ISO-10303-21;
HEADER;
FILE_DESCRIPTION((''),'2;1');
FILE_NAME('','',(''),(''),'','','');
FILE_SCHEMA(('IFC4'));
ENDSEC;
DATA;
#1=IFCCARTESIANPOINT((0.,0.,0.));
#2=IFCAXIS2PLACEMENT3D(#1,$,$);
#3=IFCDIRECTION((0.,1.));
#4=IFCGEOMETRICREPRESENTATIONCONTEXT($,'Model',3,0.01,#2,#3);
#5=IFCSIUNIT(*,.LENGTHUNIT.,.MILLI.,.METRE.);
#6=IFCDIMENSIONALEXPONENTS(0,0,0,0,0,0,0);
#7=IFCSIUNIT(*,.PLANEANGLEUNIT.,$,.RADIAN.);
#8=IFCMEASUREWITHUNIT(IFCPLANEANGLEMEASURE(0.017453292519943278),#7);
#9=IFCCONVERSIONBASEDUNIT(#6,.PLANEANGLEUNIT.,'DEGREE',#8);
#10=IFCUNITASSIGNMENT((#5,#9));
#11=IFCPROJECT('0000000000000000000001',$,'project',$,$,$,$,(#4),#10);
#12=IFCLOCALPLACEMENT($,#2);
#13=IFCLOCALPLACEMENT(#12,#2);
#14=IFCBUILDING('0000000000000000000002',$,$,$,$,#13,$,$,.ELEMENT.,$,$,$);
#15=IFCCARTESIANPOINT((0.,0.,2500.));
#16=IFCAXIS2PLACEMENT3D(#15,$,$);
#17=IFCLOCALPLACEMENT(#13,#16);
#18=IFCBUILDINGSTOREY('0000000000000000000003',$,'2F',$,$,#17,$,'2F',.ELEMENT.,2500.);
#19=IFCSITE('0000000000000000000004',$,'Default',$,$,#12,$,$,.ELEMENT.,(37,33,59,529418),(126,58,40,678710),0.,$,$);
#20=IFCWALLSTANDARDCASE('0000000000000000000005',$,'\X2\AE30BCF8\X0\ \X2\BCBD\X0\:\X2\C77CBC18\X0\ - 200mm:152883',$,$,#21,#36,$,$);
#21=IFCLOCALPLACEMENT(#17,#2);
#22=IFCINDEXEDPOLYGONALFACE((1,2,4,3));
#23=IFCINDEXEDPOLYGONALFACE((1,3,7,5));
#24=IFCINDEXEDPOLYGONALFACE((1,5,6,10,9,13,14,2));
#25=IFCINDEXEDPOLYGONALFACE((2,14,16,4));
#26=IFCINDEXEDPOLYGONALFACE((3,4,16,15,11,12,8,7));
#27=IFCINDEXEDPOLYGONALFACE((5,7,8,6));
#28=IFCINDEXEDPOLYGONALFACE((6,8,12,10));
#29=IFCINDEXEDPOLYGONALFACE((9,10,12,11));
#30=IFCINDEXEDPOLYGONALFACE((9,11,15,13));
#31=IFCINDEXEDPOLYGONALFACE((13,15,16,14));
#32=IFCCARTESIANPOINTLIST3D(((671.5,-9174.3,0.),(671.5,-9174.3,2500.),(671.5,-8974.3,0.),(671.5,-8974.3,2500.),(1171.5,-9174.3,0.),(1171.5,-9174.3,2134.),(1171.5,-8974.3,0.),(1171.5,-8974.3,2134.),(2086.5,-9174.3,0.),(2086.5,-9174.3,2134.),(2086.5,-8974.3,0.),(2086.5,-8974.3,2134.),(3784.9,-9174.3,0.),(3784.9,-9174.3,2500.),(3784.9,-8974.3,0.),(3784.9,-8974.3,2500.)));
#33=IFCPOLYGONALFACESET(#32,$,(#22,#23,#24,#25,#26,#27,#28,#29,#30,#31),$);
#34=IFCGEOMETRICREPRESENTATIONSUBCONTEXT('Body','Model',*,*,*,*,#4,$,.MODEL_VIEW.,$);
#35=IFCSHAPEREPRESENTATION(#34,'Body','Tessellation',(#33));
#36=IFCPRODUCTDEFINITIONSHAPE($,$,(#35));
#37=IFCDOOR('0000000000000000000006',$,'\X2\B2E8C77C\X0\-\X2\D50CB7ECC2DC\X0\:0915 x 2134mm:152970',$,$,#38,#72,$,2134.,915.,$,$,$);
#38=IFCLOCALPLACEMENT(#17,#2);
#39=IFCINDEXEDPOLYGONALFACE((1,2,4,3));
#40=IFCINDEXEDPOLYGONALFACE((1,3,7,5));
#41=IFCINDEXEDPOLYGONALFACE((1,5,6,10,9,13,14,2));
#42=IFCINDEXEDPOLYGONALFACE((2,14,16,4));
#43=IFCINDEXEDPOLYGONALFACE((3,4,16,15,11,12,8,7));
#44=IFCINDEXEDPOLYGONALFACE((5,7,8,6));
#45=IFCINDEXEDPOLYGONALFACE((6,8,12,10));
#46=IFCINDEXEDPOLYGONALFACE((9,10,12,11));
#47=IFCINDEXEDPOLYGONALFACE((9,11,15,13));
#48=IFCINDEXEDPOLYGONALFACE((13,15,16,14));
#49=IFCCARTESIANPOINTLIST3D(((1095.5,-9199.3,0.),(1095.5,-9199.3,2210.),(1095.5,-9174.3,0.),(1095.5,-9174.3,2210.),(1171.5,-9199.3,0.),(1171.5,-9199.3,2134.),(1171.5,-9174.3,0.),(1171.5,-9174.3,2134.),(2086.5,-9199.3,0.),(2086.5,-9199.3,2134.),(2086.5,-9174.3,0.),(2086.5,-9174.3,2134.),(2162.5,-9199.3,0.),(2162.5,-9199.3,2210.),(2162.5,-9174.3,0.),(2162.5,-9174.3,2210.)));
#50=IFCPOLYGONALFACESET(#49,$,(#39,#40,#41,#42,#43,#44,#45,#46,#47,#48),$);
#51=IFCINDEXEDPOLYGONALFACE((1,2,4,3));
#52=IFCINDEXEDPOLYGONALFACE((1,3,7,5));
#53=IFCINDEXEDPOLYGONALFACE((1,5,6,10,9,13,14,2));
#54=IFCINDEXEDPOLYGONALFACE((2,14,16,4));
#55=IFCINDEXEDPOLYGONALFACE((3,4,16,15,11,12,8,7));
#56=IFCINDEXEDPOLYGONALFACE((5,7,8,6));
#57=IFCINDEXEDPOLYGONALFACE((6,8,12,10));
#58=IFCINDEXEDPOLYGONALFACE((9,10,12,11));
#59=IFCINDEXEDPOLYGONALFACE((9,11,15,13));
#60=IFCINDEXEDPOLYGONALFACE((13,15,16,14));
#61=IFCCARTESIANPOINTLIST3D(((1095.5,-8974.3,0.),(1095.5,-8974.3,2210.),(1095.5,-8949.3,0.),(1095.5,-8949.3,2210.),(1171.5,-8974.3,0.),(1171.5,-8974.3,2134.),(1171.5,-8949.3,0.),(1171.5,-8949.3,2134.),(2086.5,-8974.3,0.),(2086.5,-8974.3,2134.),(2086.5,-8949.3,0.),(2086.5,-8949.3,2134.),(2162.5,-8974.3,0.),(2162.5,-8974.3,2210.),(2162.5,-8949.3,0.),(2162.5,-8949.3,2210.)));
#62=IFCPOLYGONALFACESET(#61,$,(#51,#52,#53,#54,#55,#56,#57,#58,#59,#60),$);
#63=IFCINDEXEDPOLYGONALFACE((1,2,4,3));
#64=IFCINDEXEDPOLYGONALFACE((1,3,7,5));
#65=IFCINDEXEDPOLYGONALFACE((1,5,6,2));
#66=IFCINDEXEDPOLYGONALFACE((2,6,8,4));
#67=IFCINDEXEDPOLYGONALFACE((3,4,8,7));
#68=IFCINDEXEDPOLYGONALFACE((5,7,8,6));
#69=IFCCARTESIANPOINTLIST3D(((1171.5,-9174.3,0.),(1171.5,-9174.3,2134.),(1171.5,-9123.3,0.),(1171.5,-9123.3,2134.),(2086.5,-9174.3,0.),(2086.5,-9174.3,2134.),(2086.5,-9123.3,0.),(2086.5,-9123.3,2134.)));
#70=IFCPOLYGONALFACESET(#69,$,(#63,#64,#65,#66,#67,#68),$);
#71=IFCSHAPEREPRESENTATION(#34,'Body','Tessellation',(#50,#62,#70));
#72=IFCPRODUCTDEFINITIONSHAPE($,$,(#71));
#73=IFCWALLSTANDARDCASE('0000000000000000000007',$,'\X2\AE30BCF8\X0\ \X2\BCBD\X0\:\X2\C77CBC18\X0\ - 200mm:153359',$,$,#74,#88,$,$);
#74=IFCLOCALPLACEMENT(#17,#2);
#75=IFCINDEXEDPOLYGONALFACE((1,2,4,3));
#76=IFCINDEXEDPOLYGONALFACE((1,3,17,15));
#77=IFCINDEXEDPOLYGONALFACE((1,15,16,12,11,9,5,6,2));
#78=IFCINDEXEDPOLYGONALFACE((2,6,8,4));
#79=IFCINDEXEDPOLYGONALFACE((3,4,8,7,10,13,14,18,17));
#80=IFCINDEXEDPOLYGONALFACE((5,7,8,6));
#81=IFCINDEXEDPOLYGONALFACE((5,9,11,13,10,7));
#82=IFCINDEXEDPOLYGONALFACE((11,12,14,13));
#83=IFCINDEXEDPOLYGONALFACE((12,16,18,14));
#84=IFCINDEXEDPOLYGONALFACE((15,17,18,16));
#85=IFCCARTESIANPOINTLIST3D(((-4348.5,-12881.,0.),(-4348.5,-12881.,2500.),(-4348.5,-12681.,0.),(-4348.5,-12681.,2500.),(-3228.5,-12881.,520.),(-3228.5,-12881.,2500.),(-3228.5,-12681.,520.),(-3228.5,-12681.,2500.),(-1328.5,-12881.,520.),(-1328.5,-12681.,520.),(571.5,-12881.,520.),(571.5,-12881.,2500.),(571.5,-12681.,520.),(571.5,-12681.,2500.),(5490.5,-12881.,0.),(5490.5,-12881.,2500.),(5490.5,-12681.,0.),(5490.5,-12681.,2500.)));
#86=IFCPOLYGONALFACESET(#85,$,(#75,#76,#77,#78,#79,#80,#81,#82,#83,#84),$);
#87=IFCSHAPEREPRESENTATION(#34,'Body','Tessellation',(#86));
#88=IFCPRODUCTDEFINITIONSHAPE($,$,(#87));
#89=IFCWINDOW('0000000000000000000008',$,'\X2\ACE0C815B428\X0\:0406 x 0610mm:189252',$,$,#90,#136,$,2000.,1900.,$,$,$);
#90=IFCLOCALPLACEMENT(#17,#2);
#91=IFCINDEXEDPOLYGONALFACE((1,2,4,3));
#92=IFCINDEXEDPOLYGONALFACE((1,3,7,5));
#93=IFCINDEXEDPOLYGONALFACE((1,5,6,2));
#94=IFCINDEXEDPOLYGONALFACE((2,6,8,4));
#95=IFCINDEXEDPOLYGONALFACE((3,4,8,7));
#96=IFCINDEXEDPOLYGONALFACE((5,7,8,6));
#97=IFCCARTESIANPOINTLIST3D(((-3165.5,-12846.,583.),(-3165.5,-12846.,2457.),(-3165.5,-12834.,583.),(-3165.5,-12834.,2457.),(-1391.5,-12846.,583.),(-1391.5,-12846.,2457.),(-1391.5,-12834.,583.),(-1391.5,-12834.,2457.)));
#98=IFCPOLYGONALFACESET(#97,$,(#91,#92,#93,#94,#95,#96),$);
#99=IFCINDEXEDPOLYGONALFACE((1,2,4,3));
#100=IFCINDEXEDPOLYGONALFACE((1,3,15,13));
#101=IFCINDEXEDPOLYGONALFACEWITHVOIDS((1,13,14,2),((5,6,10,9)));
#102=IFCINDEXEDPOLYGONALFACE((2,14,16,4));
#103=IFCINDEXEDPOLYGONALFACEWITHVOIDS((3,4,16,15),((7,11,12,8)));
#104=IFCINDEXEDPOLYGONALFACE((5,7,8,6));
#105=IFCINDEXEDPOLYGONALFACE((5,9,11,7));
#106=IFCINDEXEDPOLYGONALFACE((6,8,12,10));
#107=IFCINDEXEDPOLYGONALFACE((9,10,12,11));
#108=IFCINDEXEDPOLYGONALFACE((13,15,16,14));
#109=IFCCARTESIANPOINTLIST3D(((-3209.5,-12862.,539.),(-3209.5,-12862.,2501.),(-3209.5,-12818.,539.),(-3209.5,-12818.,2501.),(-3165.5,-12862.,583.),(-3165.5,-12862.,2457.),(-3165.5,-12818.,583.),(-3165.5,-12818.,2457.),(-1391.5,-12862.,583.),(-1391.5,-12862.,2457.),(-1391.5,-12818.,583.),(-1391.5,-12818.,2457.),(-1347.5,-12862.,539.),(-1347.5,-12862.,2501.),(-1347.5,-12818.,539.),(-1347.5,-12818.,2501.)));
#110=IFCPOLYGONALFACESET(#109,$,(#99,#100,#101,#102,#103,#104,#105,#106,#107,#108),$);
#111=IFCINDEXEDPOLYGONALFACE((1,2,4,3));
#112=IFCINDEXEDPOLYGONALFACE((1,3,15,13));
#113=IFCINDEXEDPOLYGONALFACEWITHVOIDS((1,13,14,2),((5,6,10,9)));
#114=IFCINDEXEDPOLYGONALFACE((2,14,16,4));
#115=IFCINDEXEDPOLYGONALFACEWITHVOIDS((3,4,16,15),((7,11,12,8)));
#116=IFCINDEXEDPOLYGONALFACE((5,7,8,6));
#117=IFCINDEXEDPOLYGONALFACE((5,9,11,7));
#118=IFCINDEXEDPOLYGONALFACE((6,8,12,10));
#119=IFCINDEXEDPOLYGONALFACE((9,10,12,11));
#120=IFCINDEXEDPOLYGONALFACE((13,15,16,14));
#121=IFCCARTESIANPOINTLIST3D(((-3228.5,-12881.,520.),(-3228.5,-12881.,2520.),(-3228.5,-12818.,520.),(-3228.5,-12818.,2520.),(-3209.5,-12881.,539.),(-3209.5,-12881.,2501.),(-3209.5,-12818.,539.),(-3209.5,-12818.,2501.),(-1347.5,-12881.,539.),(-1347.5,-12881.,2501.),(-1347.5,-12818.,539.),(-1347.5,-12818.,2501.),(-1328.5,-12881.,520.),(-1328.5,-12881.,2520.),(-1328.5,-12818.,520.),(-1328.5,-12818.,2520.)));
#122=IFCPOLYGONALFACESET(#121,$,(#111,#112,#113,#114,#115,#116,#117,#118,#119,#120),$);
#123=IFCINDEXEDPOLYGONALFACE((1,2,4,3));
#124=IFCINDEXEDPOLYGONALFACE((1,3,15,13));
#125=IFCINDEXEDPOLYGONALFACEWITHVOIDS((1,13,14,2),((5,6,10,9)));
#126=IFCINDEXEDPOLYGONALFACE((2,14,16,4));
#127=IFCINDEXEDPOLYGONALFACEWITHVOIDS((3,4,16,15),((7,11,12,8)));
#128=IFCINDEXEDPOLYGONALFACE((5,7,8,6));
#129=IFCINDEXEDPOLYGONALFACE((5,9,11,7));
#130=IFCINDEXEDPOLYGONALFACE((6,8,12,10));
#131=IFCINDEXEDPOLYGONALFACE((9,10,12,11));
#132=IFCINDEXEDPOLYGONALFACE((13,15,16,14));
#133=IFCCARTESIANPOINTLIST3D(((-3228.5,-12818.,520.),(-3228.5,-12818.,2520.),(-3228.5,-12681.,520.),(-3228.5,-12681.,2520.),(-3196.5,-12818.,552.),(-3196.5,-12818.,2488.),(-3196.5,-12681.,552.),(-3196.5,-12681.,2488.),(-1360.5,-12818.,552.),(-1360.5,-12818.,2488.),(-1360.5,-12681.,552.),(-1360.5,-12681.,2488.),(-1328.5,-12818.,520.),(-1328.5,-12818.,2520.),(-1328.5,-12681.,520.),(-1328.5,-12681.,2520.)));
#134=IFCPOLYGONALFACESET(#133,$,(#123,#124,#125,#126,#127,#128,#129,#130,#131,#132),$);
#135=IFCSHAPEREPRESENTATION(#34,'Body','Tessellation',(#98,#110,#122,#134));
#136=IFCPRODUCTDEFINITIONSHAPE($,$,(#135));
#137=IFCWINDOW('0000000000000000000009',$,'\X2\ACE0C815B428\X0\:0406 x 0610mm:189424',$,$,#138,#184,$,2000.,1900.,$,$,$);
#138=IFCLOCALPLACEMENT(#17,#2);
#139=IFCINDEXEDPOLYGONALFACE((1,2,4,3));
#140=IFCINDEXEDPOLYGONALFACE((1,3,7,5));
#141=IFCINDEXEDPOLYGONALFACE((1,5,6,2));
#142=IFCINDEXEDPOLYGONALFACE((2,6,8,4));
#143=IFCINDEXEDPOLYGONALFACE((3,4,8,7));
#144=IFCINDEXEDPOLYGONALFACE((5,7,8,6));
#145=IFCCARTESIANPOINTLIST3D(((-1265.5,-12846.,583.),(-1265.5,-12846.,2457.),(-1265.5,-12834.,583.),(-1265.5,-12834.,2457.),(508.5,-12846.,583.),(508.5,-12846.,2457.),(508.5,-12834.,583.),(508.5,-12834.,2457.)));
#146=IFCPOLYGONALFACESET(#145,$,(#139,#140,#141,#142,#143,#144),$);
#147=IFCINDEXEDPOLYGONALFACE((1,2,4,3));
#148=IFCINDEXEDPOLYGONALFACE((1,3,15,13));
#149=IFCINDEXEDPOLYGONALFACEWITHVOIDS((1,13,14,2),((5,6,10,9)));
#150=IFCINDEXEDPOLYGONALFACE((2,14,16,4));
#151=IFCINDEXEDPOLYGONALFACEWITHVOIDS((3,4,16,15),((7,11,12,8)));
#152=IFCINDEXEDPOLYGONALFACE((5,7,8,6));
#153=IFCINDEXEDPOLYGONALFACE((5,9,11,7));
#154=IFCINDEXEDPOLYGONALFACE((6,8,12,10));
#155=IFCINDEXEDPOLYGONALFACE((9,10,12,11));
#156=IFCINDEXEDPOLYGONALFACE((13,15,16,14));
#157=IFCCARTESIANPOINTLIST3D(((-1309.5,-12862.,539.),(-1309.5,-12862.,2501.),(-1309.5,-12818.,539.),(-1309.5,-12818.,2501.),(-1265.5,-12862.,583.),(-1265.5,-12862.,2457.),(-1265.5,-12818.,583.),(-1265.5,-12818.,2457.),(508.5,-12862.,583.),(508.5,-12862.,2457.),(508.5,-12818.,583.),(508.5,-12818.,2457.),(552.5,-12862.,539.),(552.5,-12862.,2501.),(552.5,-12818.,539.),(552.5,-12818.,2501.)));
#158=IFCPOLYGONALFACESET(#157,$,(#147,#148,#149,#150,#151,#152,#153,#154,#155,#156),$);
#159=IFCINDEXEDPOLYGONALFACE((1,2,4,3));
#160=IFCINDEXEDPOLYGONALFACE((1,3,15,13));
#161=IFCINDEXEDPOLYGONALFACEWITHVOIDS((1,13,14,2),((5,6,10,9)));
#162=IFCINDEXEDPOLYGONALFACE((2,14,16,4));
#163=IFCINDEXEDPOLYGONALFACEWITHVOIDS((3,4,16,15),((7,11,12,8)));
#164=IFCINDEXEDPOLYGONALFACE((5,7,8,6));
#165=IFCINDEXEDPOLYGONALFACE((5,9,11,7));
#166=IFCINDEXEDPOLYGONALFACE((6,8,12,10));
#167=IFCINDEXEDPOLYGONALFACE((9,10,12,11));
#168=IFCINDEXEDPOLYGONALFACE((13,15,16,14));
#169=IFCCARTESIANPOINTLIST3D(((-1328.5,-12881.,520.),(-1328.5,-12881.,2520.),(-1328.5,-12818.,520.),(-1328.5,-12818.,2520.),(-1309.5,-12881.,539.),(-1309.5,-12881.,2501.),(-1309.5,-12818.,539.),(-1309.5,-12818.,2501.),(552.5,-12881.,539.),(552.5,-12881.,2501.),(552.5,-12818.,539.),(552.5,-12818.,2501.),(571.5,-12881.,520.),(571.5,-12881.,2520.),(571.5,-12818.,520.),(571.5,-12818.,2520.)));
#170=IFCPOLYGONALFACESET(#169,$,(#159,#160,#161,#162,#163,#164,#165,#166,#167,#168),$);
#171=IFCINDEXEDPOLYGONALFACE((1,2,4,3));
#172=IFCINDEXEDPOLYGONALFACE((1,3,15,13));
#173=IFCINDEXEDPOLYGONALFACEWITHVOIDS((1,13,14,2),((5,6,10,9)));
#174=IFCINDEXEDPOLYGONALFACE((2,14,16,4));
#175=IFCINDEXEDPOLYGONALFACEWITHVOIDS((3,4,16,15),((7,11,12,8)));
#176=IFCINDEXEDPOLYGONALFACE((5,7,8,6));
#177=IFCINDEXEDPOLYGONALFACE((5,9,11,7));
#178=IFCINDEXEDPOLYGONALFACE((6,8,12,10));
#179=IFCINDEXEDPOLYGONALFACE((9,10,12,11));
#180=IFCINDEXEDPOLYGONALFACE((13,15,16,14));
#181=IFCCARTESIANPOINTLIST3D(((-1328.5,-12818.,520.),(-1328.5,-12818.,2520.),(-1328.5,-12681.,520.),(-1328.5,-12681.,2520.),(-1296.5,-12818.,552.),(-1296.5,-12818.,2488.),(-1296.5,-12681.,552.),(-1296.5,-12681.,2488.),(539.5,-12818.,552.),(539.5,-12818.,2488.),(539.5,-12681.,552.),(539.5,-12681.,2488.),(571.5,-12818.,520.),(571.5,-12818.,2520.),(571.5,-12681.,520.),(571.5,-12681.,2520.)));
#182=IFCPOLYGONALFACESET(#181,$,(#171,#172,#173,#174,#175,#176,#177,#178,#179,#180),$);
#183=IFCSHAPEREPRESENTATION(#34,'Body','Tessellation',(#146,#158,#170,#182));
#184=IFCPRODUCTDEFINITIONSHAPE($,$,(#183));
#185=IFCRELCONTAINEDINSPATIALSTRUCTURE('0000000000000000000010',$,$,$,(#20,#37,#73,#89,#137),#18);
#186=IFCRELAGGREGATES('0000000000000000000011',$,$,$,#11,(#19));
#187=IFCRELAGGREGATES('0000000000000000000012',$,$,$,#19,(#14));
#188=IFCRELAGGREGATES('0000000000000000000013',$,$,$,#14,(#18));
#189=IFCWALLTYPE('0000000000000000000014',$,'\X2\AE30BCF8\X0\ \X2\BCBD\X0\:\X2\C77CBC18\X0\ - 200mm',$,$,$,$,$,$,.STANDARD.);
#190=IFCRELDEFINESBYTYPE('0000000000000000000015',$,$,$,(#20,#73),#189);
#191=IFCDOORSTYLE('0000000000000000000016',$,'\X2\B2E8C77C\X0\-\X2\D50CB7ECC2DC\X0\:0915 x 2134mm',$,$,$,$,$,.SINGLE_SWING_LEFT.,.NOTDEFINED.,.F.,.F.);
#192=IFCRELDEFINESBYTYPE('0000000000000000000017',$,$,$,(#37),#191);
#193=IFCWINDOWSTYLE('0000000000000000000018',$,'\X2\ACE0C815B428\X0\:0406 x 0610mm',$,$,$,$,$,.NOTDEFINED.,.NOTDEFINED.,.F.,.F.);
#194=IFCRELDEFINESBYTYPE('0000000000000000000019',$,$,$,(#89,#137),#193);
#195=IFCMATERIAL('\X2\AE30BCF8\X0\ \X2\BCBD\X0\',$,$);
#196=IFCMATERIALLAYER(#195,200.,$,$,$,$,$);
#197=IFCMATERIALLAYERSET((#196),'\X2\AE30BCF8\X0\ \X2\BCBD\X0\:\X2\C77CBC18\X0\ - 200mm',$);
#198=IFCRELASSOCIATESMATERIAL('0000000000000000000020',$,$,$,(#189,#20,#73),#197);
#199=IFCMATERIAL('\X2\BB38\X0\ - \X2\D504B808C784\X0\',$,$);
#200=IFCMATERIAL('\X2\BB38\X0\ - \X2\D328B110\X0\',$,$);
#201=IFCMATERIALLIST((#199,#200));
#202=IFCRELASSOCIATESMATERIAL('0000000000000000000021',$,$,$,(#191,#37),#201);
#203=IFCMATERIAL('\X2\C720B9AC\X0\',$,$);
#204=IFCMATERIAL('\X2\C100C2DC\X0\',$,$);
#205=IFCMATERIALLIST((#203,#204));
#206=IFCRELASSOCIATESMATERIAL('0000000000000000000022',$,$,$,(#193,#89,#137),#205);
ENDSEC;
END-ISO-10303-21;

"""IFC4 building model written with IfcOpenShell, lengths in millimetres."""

from ifc_helpers import new_model, entity, si_unit, converted_unit, direction, frame, frame_2d, origin, place, context, subcontext, project, spatial, polyline, rectangle, outline, extrude, source, transform, mapped, material, material_list, layer, layer_set, layer_usage, type_object, type_shapes, element, fill, save


model = new_model("IFC4")

# Units and contexts
model_context = context("Model", 3, precision=0.01, world=origin(), true_north=direction((0.0, 1.0)))
body_context = subcontext(model_context, "Body", "Model", "MODEL_VIEW")
ifc_project = project(units=[si_unit("LENGTHUNIT", "METRE", prefix="MILLI"), converted_unit("PLANEANGLEUNIT", "DEGREE", entity("IfcPlaneAngleMeasure", 0.017453292519943278), si_unit("PLANEANGLEUNIT", "RADIAN"), dimensions=[0, 0, 0, 0, 0, 0, 0])], contexts=[model_context])

# Site, building, storey
site_placement = place(None, origin())
site = spatial("IfcSite", under=ifc_project, at=site_placement, Name="Default", CompositionType="ELEMENT", RefLatitude=(37, 33, 59, 529418), RefLongitude=(126, 58, 40, 678710), RefElevation=0.0)
building_placement = place(site_placement, origin())
building = spatial("IfcBuilding", under=site, at=building_placement, CompositionType="ELEMENT")
storey_placement = place(building_placement, frame((0.0, 0.0, 2500.0)))
storey = spatial("IfcBuildingStorey", under=building, at=storey_placement, Name="2F", LongName="2F", CompositionType="ELEMENT", Elevation=2500.0)

# Wall, opening, door
ifc_material_1 = material(Name="기본 벽")
ifc_layer_1 = layer(ifc_material_1, 200.0)
ifc_layer_set_1 = layer_set([ifc_layer_1], Name="기본 벽:일반 - 200mm")
ifc_layer_usage_1 = layer_usage(ifc_layer_set_1, "AXIS2", "NEGATIVE", 100.0)
wall_type = type_object("IfcWallType", Name="기본 벽:일반 - 200mm", PredefinedType="STANDARD", material=ifc_layer_set_1)
wall_1_placement = place(storey_placement, frame((671.5, -9074.3, 0.0)))
wall_1 = element("IfcWallStandardCase", 1, at=wall_1_placement, inside=storey, type_object=wall_type, material=ifc_layer_usage_1, Name="기본 벽:일반 - 200mm:152883", context=body_context, shape_type="SweptSolid", body=[
    extrude(rectangle(XDim=3113.4, YDim=200.0, at=frame_2d((1556.7, 0.0), x_axis=(-1.0, 0.0))), origin(), (0.0, 0.0, 1.0), 2500.0),
])
opening_1_placement = place(wall_1_placement, frame((1415.0, 100.0, 0.0)))
opening_1 = element("IfcOpeningElement", 2, at=opening_1_placement, cuts=wall_1, ObjectType="Opening", context=body_context, shape_type="SweptSolid", body=[
    extrude(rectangle(XDim=915.0, YDim=2134.0, at=frame_2d((1067.0, 457.5), x_axis=(0.0, -1.0))), frame((0.0, 0.0, 0.0), z_axis=(0.0, -1.0, 0.0), x_axis=(0.0, 0.0, 1.0)), (0.0, 0.0, 1.0), 200.0),
])
ifc_material_2 = material(Name="문 - 프레임")
ifc_material_3 = material(Name="문 - 패널")
ifc_material_list_1 = material_list([ifc_material_2, ifc_material_3])
door_style = type_object("IfcDoorStyle", Name="단일-플러시:0915 x 2134mm", ConstructionType="NOTDEFINED", OperationType="SINGLE_SWING_LEFT", ParameterTakesPrecedence=False, Sizeable=False, material=ifc_material_list_1)
shared_shape_1 = source(origin(), body_context, "Body", "SweptSolid", [
    extrude(outline(polyline([(-533.5, -1124.0), (533.5, -1124.0), (533.5, 1086.0), (457.5, 1086.0), (457.5, -1048.0), (-457.5, -1048.0), (-457.5, 1086.0), (-533.5, 1086.0), (-533.5, -1124.0)])), frame((457.5, 225.0, 1086.0), z_axis=(0.0, -1.0, 0.0), x_axis=(-1.0, 0.0, 0.0)), (0.0, 0.0, 1.0), 25.0),
    extrude(outline(polyline([(-1124.0, -533.5), (1086.0, -533.5), (1086.0, -457.5), (-1048.0, -457.5), (-1048.0, 457.5), (1086.0, 457.5), (1086.0, 533.5), (-1124.0, 533.5), (-1124.0, -533.5)])), frame((457.5, 0.0, 1086.0), z_axis=(0.0, -1.0, 0.0), x_axis=(0.0, 0.0, -1.0)), (0.0, 0.0, 1.0), 25.0),
    extrude(rectangle(XDim=915.0, YDim=51.0, at=frame_2d((0.0, 0.0), x_axis=(1.0, 0.0))), frame((457.5, 174.5, 0.0)), (0.0, 0.0, 1.0), 2134.0),
])
type_shapes(door_style, [shared_shape_1])
door_1_placement = place(opening_1_placement, frame((0.0, 0.0, 0.0), z_axis=(0.0, 0.0, 1.0), x_axis=(-1.0, 0.0, 0.0)))
door_1 = element("IfcDoor", 3, at=door_1_placement, inside=storey, type_object=door_style, material=ifc_material_list_1, Name="단일-플러시:0915 x 2134mm:152970", OverallHeight=2134.0, OverallWidth=915.0, context=body_context, shape_type="MappedRepresentation", body=[
    mapped(shared_shape_1, transform((0.0, 0.0, 0.0), scale=1.0)),
])
fill(opening_1, door_1)

# Wall, openings, windows
ifc_layer_usage_2 = layer_usage(ifc_layer_set_1, "AXIS2", "NEGATIVE", 100.0)
wall_2_placement = place(storey_placement, frame((5490.5, -12781.0, 0.0), z_axis=(0.0, 0.0, 1.0), x_axis=(-1.0, 0.0, 0.0)))
wall_2 = element("IfcWallStandardCase", 4, at=wall_2_placement, inside=storey, type_object=wall_type, material=ifc_layer_usage_2, Name="기본 벽:일반 - 200mm:153359", context=body_context, shape_type="SweptSolid", body=[
    extrude(rectangle(XDim=9839.0, YDim=200.0, at=frame_2d((4919.5, 0.0), x_axis=(-1.0, 0.0))), origin(), (0.0, 0.0, 1.0), 2500.0),
])
opening_2_placement = place(wall_2_placement, frame((6819.0, -100.0, 520.0)))
opening_2 = element("IfcOpeningElement", 5, at=opening_2_placement, cuts=wall_2, ObjectType="Opening", context=body_context, shape_type="SweptSolid", body=[
    extrude(rectangle(XDim=2000.0, YDim=1900.0, at=frame_2d((1000.0, 950.0), x_axis=(1.0, 0.0))), frame((0.0, 0.0, 0.0), z_axis=(0.0, 1.0, 0.0), x_axis=(0.0, 0.0, 1.0)), (0.0, 0.0, 1.0), 200.0),
])
opening_3_placement = place(wall_2_placement, frame((4919.0, -100.0, 520.0)))
opening_3 = element("IfcOpeningElement", 6, at=opening_3_placement, cuts=wall_2, ObjectType="Opening", context=body_context, shape_type="SweptSolid", body=[
    extrude(rectangle(XDim=2000.0, YDim=1900.0, at=frame_2d((1000.0, 950.0), x_axis=(1.0, 0.0))), frame((0.0, 0.0, 0.0), z_axis=(0.0, 1.0, 0.0), x_axis=(0.0, 0.0, 1.0)), (0.0, 0.0, 1.0), 200.0),
])
ifc_material_4 = material(Name="유리")
ifc_material_5 = material(Name="섀시")
ifc_material_list_2 = material_list([ifc_material_4, ifc_material_5])
window_style = type_object("IfcWindowStyle", Name="고정됨:0406 x 0610mm", ConstructionType="NOTDEFINED", OperationType="NOTDEFINED", ParameterTakesPrecedence=False, Sizeable=False, material=ifc_material_list_2)
shared_shape_2 = source(origin(), body_context, "Body", "SweptSolid", [
    extrude(rectangle(XDim=12.0, YDim=1774.0, at=frame_2d((0.0, 0.0), x_axis=(1.0, 0.0))), frame((950.0, 159.0, 63.0), z_axis=(0.0, 0.0, 1.0), x_axis=(0.0, -1.0, 0.0)), (0.0, 0.0, 1.0), 1874.0),
    extrude(outline(polyline([(-931.0, -981.0), (931.0, -981.0), (931.0, 981.0), (-931.0, 981.0), (-931.0, -981.0)]), holes=[polyline([(-887.0, -937.0), (-887.0, 937.0), (887.0, 937.0), (887.0, -937.0), (-887.0, -937.0)])]), frame((950.0, 137.0, 1000.0), z_axis=(0.0, 1.0, 0.0), x_axis=(1.0, 0.0, 0.0)), (0.0, 0.0, 1.0), 44.0),
    extrude(outline(polyline([(-950.0, -1000.0), (950.0, -1000.0), (950.0, 1000.0), (-950.0, 1000.0), (-950.0, -1000.0)]), holes=[polyline([(-931.0, -981.0), (-931.0, 981.0), (931.0, 981.0), (931.0, -981.0), (-931.0, -981.0)])]), frame((950.0, 137.0, 1000.0), z_axis=(0.0, 1.0, 0.0), x_axis=(1.0, 0.0, 0.0)), (0.0, 0.0, 1.0), 63.0),
    extrude(outline(polyline([(-950.0, -1000.0), (950.0, -1000.0), (950.0, 1000.0), (-950.0, 1000.0), (-950.0, -1000.0)]), holes=[polyline([(-918.0, -968.0), (-918.0, 968.0), (918.0, 968.0), (918.0, -968.0), (-918.0, -968.0)])]), frame((950.0, 0.0, 1000.0), z_axis=(0.0, 1.0, 0.0), x_axis=(1.0, 0.0, 0.0)), (0.0, 0.0, 1.0), 137.0),
])
type_shapes(window_style, [shared_shape_2])
window_1_placement = place(opening_2_placement, origin())
window_1 = element("IfcWindow", 7, at=window_1_placement, inside=storey, type_object=window_style, material=ifc_material_list_2, Name="고정됨:0406 x 0610mm:189252", OverallHeight=2000.0, OverallWidth=1900.0, context=body_context, shape_type="MappedRepresentation", body=[
    mapped(shared_shape_2, transform((0.0, 0.0, 0.0), scale=1.0)),
])
fill(opening_2, window_1)
window_2_placement = place(opening_3_placement, origin())
window_2 = element("IfcWindow", 8, at=window_2_placement, inside=storey, type_object=window_style, material=ifc_material_list_2, Name="고정됨:0406 x 0610mm:189424", OverallHeight=2000.0, OverallWidth=1900.0, context=body_context, shape_type="MappedRepresentation", body=[
    mapped(shared_shape_2, transform((0.0, 0.0, 0.0), scale=1.0)),
])
fill(opening_3, window_2)

save(model, "model.ifc")
